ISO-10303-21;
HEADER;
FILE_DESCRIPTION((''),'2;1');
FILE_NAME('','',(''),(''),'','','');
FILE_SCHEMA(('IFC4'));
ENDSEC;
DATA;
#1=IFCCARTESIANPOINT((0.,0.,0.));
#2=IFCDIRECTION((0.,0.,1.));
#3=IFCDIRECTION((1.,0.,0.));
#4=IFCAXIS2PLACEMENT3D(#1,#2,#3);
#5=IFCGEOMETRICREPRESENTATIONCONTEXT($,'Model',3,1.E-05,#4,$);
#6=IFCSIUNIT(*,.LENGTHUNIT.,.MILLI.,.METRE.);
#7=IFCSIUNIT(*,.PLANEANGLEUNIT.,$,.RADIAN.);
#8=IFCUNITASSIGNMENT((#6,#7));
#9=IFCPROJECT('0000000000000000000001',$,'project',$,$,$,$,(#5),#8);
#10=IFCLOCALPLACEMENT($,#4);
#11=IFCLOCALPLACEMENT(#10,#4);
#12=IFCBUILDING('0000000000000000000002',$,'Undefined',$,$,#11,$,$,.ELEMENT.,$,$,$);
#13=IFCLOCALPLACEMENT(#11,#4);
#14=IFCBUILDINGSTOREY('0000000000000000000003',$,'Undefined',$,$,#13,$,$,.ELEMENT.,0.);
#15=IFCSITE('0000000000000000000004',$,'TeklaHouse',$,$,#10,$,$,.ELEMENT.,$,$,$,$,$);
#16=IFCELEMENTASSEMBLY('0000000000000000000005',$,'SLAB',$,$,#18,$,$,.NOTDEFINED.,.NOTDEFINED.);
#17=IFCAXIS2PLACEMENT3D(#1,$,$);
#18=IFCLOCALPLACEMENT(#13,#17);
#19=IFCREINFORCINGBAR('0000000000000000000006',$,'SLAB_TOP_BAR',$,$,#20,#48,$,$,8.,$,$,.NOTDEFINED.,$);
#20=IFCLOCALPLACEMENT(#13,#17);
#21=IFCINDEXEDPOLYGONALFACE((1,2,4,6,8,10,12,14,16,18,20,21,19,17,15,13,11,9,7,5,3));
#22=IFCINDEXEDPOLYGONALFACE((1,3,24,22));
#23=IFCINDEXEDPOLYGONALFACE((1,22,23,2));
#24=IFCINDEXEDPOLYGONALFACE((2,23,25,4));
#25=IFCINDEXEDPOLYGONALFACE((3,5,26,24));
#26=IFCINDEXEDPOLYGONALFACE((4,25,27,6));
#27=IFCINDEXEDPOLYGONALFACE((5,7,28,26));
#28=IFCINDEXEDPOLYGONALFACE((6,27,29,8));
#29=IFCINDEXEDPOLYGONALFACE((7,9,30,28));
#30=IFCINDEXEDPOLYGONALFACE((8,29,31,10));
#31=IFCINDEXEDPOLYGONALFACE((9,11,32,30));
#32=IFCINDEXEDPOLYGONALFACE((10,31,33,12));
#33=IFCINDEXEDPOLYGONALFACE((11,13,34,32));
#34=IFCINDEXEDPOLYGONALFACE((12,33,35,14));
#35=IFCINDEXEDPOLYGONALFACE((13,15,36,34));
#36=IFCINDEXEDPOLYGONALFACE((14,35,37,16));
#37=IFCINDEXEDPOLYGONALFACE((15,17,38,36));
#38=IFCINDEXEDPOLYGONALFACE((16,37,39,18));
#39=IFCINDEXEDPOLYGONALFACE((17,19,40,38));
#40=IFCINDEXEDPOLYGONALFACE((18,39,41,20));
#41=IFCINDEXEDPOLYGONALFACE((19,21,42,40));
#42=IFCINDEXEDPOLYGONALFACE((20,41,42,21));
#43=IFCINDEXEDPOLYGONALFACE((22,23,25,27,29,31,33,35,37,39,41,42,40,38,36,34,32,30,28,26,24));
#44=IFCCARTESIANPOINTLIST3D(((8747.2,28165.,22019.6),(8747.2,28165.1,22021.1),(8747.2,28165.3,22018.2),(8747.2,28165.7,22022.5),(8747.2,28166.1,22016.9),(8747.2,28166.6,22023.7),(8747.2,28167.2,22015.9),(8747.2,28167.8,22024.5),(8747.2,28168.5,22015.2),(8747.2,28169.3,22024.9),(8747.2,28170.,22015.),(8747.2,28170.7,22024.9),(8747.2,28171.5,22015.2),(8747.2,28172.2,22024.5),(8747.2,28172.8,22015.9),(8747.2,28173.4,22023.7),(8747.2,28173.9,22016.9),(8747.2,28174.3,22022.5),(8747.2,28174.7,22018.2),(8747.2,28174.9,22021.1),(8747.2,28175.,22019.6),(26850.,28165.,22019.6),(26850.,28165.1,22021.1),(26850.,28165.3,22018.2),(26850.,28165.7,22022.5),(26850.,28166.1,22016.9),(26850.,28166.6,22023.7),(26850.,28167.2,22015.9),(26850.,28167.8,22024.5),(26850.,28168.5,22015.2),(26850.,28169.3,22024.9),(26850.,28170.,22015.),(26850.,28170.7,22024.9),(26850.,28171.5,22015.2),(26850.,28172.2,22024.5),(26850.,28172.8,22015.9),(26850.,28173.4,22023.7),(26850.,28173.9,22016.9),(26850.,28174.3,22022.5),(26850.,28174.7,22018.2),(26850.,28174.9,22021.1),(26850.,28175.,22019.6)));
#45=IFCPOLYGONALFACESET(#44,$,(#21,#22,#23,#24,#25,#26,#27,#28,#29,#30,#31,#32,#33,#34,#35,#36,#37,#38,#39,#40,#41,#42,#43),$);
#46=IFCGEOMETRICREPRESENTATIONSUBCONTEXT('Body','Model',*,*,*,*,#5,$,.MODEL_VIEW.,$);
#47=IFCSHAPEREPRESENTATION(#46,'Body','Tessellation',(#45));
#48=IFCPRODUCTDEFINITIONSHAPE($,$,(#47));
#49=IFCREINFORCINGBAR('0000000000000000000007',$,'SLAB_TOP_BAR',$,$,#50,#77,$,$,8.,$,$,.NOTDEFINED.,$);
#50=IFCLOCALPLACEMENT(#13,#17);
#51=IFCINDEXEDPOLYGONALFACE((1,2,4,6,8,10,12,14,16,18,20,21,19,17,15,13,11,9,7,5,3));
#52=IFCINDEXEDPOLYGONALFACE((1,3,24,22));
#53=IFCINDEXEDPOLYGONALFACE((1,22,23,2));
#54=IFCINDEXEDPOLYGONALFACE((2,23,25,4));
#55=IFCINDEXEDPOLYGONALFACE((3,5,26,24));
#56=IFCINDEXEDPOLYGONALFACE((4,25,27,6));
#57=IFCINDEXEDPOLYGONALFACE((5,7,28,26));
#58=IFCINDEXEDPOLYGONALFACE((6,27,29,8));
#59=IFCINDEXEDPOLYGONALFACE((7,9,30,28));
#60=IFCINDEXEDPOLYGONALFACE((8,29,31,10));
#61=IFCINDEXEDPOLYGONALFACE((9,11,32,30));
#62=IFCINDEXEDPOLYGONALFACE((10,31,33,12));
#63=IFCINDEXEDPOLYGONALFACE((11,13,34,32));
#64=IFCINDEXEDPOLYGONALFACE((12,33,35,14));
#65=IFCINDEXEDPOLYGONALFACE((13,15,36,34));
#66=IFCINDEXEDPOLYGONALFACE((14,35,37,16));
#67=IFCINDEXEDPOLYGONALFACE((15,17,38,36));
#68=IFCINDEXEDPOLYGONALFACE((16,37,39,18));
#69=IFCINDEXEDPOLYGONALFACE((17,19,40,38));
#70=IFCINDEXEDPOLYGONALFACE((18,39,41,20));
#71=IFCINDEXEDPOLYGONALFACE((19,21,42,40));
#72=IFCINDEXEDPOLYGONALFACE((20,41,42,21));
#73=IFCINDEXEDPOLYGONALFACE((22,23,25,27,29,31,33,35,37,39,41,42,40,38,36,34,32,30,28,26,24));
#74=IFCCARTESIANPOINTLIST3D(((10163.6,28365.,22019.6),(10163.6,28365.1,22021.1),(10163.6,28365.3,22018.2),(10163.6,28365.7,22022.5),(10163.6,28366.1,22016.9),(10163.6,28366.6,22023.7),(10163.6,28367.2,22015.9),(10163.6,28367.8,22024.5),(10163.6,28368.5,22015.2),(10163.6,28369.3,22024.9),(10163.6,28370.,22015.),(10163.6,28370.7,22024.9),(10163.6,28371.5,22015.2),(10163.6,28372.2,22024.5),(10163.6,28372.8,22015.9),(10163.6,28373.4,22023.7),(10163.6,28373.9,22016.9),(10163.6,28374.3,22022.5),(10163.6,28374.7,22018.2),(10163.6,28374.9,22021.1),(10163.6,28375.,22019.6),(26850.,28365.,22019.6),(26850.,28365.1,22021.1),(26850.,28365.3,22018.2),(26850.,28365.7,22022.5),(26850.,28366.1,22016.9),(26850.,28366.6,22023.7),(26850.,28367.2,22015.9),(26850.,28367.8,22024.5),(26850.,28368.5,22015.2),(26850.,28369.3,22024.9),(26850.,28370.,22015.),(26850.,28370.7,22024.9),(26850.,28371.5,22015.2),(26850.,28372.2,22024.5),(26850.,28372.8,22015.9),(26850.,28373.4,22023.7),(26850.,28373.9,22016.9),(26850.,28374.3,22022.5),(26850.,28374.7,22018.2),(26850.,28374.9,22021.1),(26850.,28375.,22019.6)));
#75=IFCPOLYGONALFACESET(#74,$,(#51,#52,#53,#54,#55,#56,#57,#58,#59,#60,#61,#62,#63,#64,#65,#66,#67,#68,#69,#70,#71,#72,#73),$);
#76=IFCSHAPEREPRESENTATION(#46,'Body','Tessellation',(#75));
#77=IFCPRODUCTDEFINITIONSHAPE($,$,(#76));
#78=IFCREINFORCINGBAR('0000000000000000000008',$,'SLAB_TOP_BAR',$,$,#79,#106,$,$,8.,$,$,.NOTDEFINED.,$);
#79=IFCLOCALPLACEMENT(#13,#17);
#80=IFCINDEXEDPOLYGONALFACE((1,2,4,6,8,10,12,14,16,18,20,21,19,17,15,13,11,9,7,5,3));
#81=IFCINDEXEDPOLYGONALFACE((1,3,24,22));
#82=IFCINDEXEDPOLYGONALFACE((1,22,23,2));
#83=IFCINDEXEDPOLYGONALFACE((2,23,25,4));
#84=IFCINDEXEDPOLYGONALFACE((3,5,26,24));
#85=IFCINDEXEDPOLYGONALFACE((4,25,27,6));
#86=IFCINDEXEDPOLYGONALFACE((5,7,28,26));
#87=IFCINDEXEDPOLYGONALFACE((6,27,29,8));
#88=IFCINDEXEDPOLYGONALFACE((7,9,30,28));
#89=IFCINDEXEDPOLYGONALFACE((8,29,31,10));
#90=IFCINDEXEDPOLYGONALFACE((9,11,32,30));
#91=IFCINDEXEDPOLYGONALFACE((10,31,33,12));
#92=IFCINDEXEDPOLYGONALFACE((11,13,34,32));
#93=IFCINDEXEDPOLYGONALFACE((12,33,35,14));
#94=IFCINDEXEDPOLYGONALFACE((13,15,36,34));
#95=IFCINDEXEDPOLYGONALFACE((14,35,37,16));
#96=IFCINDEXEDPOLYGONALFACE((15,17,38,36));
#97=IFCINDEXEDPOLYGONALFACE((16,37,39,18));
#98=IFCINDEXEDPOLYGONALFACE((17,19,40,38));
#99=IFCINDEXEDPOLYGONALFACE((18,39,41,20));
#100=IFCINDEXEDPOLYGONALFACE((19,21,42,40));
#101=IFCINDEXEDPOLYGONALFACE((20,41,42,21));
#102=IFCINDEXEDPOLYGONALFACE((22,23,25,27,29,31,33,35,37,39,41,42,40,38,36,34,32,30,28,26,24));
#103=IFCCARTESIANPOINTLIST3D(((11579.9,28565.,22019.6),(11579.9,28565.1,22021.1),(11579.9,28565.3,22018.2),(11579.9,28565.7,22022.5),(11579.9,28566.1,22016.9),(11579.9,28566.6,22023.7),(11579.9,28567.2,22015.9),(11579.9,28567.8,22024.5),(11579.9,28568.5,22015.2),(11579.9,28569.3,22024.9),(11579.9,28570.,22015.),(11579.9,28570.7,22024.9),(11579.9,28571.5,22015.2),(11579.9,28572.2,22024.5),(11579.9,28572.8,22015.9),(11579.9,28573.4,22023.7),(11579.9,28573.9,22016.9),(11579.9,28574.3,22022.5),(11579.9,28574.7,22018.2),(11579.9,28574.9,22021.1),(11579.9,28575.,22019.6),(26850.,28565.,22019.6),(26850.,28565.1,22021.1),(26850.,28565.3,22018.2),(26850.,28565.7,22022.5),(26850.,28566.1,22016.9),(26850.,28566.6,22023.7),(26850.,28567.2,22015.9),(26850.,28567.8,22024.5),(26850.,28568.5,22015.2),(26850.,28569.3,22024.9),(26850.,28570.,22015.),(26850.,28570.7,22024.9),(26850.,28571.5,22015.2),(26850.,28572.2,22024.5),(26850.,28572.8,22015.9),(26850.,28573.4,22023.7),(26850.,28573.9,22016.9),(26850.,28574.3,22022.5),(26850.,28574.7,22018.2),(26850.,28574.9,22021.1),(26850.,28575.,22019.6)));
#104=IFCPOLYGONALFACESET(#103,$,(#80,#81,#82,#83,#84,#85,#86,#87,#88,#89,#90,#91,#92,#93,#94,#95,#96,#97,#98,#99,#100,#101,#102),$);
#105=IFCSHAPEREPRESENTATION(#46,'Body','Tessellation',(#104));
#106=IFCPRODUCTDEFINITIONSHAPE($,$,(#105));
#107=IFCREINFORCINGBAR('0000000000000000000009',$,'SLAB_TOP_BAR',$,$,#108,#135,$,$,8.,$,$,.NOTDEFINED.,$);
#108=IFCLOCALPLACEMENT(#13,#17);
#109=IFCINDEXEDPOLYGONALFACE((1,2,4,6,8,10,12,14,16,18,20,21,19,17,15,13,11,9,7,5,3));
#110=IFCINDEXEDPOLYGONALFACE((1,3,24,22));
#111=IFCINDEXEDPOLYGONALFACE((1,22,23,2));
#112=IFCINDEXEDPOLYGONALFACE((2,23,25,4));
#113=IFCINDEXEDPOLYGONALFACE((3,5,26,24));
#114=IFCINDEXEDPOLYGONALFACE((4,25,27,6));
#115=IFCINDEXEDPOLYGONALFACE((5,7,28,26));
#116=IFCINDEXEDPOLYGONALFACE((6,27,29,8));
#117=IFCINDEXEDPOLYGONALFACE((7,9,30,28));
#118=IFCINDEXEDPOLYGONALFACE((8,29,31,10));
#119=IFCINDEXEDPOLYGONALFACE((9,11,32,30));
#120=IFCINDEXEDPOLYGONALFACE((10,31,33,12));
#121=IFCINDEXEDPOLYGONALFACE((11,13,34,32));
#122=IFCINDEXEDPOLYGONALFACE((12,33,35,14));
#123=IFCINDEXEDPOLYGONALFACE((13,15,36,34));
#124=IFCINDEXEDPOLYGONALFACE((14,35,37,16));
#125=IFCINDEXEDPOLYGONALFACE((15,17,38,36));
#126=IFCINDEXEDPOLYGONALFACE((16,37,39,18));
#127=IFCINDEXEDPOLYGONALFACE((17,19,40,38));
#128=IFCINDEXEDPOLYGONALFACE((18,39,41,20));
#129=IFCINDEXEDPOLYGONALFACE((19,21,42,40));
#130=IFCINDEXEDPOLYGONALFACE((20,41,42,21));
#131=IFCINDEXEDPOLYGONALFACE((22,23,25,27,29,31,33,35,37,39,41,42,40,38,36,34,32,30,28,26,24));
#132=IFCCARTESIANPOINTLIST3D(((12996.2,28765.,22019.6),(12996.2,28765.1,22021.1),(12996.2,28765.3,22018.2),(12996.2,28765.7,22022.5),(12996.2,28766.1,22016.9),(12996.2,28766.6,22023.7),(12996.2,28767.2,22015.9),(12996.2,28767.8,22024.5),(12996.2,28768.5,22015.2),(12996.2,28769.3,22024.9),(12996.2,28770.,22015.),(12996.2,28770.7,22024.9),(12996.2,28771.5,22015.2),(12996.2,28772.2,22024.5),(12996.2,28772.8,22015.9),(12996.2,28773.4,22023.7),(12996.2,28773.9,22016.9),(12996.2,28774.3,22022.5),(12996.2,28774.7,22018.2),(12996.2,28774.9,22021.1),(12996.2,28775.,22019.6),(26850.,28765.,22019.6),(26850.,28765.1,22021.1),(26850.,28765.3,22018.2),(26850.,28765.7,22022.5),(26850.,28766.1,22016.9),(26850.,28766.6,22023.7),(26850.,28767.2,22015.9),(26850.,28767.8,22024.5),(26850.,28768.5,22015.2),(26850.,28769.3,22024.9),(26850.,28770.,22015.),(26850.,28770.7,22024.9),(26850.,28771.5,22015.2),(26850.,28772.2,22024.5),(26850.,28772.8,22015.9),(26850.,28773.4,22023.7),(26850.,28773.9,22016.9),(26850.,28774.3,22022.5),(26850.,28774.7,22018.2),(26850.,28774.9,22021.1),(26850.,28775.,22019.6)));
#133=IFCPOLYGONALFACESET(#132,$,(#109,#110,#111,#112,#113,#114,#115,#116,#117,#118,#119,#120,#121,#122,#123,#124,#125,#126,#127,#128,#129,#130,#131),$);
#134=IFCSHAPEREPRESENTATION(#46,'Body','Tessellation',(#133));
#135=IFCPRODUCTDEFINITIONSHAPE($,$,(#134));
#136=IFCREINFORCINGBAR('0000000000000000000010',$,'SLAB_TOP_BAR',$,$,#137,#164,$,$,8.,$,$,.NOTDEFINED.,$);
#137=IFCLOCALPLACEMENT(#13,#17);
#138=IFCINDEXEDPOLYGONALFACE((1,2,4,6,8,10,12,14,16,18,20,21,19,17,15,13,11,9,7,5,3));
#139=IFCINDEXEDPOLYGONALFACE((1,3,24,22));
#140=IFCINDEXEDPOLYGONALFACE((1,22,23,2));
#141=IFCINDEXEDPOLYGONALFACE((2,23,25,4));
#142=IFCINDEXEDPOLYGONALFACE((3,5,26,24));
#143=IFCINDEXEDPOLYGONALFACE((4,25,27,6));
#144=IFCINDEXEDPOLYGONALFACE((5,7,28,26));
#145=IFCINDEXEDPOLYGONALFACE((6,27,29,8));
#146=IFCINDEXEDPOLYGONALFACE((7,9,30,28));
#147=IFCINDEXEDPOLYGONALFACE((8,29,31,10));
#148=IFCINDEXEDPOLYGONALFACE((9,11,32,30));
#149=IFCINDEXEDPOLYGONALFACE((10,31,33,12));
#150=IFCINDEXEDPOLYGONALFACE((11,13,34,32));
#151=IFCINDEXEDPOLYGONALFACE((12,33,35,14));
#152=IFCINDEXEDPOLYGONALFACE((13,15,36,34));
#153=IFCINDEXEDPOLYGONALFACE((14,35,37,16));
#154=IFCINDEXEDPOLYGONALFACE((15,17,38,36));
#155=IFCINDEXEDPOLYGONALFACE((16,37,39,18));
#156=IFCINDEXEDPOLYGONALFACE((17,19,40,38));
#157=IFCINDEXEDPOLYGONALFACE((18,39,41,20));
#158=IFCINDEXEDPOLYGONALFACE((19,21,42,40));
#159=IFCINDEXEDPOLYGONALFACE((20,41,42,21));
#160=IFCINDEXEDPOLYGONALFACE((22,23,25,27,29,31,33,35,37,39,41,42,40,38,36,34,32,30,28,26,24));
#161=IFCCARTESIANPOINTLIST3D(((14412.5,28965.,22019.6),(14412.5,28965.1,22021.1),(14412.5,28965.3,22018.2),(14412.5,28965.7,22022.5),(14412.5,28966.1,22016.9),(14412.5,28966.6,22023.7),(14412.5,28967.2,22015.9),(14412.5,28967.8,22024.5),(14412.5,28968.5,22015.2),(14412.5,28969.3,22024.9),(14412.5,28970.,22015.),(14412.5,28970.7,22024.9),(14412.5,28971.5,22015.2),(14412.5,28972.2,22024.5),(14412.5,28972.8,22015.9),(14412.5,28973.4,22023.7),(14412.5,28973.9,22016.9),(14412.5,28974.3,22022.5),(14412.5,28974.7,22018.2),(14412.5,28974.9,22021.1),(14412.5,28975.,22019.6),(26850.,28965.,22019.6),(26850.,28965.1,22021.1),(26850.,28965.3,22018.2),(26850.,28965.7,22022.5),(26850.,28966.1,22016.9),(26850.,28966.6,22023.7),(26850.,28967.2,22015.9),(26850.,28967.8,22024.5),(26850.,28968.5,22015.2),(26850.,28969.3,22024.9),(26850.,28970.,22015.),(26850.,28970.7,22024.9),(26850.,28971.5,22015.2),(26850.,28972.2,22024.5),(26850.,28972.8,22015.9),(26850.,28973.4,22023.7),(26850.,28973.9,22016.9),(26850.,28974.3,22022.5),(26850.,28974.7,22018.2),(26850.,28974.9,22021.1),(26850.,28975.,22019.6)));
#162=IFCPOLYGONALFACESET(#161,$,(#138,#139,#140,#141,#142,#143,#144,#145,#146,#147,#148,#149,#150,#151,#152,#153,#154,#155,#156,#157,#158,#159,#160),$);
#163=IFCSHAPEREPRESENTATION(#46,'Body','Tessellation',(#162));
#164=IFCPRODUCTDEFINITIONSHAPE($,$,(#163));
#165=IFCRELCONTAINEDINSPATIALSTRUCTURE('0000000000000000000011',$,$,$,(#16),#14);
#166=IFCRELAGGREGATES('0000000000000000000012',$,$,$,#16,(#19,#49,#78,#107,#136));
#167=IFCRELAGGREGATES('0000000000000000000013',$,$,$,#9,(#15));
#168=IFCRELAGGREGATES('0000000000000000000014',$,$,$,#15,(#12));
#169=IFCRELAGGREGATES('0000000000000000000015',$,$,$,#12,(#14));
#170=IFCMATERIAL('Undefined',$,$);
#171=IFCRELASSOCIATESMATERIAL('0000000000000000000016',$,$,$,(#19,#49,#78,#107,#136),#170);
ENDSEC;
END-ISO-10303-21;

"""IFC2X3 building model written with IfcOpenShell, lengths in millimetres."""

from ifc_helpers import new_model, entity, si_unit, frame, origin_with_axes, place, context, subcontext, project, spatial, source, transform, mapped, material, element, aggregate, save


model = new_model("IFC2X3")

# Units and contexts
model_context = context("Model", 3, precision=1e-05, world=origin_with_axes())
body_context = subcontext(model_context, "Body", "Model", "MODEL_VIEW")
ifc_project = project(units=[si_unit("LENGTHUNIT", "METRE", prefix="MILLI"), si_unit("PLANEANGLEUNIT", "RADIAN")], contexts=[model_context])

# Site, building, storey
site_placement = place(None, origin_with_axes())
site = spatial("IfcSite", under=ifc_project, at=site_placement, Name="TeklaHouse", CompositionType="ELEMENT")
building_placement = place(site_placement, origin_with_axes())
building = spatial("IfcBuilding", under=site, at=building_placement, Name="Undefined", CompositionType="ELEMENT")
storey_placement = place(building_placement, origin_with_axes())
storey = spatial("IfcBuildingStorey", under=building, at=storey_placement, Name="Undefined", CompositionType="ELEMENT", Elevation=0.0)

# Element assembly, reinforcing bars
assembly_1_placement = place(storey_placement, origin_with_axes())
assembly_1 = element("IfcElementAssembly", 1, at=assembly_1_placement, inside=storey, Name="SLAB", AssemblyPlace="NOTDEFINED", PredefinedType="NOTDEFINED")
ifc_material_1 = material(Name="Undefined")
shared_shape_1 = source(origin_with_axes(), body_context, "Body", "AdvancedSweptSolid", [
    entity("IfcSweptDiskSolid", entity("IfcTrimmedCurve", entity("IfcLine", entity("IfcCartesianPoint", [0.0, 0.0, 0.0]), entity("IfcVector", entity("IfcDirection", [1.0, 0.0, 0.0]), 1.0)), [entity("IfcParameterValue", 0.0)], [entity("IfcParameterValue", 18102.762081)], True, "PARAMETER"), 5.0, None, 0.0, 18102.8),
])
reinforcing_bar_1_placement = place(assembly_1_placement, frame((26850.0, 28170.0, 22020.0), z_axis=(0.0, 0.0, -1.0), x_axis=(-1.0, 0.0, 0.0)))
reinforcing_bar_1 = element("IfcReinforcingBar", 2, at=reinforcing_bar_1_placement, material=ifc_material_1, Name="SLAB_TOP_BAR", BarRole="NOTDEFINED", NominalDiameter=8.0, context=body_context, shape_type="MappedRepresentation", body=[
    mapped(shared_shape_1, transform((0.0, 0.0, 0.0))),
])
shared_shape_2 = source(origin_with_axes(), body_context, "Body", "AdvancedSweptSolid", [
    entity("IfcSweptDiskSolid", entity("IfcTrimmedCurve", entity("IfcLine", entity("IfcCartesianPoint", [0.0, 0.0, 0.0]), entity("IfcVector", entity("IfcDirection", [1.0, 0.0, 0.0]), 1.0)), [entity("IfcParameterValue", 0.0)], [entity("IfcParameterValue", 16686.437345)], True, "PARAMETER"), 5.0, None, 0.0, 16686.4),
])
reinforcing_bar_2_placement = place(assembly_1_placement, frame((26850.0, 28370.0, 22020.0), z_axis=(0.0, 0.0, -1.0), x_axis=(-1.0, 0.0, 0.0)))
reinforcing_bar_2 = element("IfcReinforcingBar", 3, at=reinforcing_bar_2_placement, material=ifc_material_1, Name="SLAB_TOP_BAR", BarRole="NOTDEFINED", NominalDiameter=8.0, context=body_context, shape_type="MappedRepresentation", body=[
    mapped(shared_shape_2, transform((0.0, 0.0, 0.0))),
])
shared_shape_3 = source(origin_with_axes(), body_context, "Body", "AdvancedSweptSolid", [
    entity("IfcSweptDiskSolid", entity("IfcTrimmedCurve", entity("IfcLine", entity("IfcCartesianPoint", [0.0, 0.0, 0.0]), entity("IfcVector", entity("IfcDirection", [1.0, 0.0, 0.0]), 1.0)), [entity("IfcParameterValue", 0.0)], [entity("IfcParameterValue", 15270.112609)], True, "PARAMETER"), 5.0, None, 0.0, 15270.1),
])
reinforcing_bar_3_placement = place(assembly_1_placement, frame((26850.0, 28570.0, 22020.0), z_axis=(0.0, 0.0, -1.0), x_axis=(-1.0, 0.0, 0.0)))
reinforcing_bar_3 = element("IfcReinforcingBar", 4, at=reinforcing_bar_3_placement, material=ifc_material_1, Name="SLAB_TOP_BAR", BarRole="NOTDEFINED", NominalDiameter=8.0, context=body_context, shape_type="MappedRepresentation", body=[
    mapped(shared_shape_3, transform((0.0, 0.0, 0.0))),
])
shared_shape_4 = source(origin_with_axes(), body_context, "Body", "AdvancedSweptSolid", [
    entity("IfcSweptDiskSolid", entity("IfcTrimmedCurve", entity("IfcLine", entity("IfcCartesianPoint", [0.0, 0.0, 0.0]), entity("IfcVector", entity("IfcDirection", [1.0, 0.0, 0.0]), 1.0)), [entity("IfcParameterValue", 0.0)], [entity("IfcParameterValue", 13853.787873)], True, "PARAMETER"), 5.0, None, 0.0, 13853.8),
])
reinforcing_bar_4_placement = place(assembly_1_placement, frame((26850.0, 28770.0, 22020.0), z_axis=(0.0, 0.0, -1.0), x_axis=(-1.0, 0.0, 0.0)))
reinforcing_bar_4 = element("IfcReinforcingBar", 5, at=reinforcing_bar_4_placement, material=ifc_material_1, Name="SLAB_TOP_BAR", BarRole="NOTDEFINED", NominalDiameter=8.0, context=body_context, shape_type="MappedRepresentation", body=[
    mapped(shared_shape_4, transform((0.0, 0.0, 0.0))),
])
shared_shape_5 = source(origin_with_axes(), body_context, "Body", "AdvancedSweptSolid", [
    entity("IfcSweptDiskSolid", entity("IfcTrimmedCurve", entity("IfcLine", entity("IfcCartesianPoint", [0.0, 0.0, 0.0]), entity("IfcVector", entity("IfcDirection", [1.0, 0.0, 0.0]), 1.0)), [entity("IfcParameterValue", 0.0)], [entity("IfcParameterValue", 12437.463137)], True, "PARAMETER"), 5.0, None, 0.0, 12437.5),
])
reinforcing_bar_5_placement = place(assembly_1_placement, frame((26850.0, 28970.0, 22020.0), z_axis=(0.0, 0.0, -1.0), x_axis=(-1.0, 0.0, 0.0)))
reinforcing_bar_5 = element("IfcReinforcingBar", 6, at=reinforcing_bar_5_placement, material=ifc_material_1, Name="SLAB_TOP_BAR", BarRole="NOTDEFINED", NominalDiameter=8.0, context=body_context, shape_type="MappedRepresentation", body=[
    mapped(shared_shape_5, transform((0.0, 0.0, 0.0))),
])
aggregate(assembly_1, [reinforcing_bar_1, reinforcing_bar_2, reinforcing_bar_3, reinforcing_bar_4, reinforcing_bar_5])

save(model, "model.ifc")
